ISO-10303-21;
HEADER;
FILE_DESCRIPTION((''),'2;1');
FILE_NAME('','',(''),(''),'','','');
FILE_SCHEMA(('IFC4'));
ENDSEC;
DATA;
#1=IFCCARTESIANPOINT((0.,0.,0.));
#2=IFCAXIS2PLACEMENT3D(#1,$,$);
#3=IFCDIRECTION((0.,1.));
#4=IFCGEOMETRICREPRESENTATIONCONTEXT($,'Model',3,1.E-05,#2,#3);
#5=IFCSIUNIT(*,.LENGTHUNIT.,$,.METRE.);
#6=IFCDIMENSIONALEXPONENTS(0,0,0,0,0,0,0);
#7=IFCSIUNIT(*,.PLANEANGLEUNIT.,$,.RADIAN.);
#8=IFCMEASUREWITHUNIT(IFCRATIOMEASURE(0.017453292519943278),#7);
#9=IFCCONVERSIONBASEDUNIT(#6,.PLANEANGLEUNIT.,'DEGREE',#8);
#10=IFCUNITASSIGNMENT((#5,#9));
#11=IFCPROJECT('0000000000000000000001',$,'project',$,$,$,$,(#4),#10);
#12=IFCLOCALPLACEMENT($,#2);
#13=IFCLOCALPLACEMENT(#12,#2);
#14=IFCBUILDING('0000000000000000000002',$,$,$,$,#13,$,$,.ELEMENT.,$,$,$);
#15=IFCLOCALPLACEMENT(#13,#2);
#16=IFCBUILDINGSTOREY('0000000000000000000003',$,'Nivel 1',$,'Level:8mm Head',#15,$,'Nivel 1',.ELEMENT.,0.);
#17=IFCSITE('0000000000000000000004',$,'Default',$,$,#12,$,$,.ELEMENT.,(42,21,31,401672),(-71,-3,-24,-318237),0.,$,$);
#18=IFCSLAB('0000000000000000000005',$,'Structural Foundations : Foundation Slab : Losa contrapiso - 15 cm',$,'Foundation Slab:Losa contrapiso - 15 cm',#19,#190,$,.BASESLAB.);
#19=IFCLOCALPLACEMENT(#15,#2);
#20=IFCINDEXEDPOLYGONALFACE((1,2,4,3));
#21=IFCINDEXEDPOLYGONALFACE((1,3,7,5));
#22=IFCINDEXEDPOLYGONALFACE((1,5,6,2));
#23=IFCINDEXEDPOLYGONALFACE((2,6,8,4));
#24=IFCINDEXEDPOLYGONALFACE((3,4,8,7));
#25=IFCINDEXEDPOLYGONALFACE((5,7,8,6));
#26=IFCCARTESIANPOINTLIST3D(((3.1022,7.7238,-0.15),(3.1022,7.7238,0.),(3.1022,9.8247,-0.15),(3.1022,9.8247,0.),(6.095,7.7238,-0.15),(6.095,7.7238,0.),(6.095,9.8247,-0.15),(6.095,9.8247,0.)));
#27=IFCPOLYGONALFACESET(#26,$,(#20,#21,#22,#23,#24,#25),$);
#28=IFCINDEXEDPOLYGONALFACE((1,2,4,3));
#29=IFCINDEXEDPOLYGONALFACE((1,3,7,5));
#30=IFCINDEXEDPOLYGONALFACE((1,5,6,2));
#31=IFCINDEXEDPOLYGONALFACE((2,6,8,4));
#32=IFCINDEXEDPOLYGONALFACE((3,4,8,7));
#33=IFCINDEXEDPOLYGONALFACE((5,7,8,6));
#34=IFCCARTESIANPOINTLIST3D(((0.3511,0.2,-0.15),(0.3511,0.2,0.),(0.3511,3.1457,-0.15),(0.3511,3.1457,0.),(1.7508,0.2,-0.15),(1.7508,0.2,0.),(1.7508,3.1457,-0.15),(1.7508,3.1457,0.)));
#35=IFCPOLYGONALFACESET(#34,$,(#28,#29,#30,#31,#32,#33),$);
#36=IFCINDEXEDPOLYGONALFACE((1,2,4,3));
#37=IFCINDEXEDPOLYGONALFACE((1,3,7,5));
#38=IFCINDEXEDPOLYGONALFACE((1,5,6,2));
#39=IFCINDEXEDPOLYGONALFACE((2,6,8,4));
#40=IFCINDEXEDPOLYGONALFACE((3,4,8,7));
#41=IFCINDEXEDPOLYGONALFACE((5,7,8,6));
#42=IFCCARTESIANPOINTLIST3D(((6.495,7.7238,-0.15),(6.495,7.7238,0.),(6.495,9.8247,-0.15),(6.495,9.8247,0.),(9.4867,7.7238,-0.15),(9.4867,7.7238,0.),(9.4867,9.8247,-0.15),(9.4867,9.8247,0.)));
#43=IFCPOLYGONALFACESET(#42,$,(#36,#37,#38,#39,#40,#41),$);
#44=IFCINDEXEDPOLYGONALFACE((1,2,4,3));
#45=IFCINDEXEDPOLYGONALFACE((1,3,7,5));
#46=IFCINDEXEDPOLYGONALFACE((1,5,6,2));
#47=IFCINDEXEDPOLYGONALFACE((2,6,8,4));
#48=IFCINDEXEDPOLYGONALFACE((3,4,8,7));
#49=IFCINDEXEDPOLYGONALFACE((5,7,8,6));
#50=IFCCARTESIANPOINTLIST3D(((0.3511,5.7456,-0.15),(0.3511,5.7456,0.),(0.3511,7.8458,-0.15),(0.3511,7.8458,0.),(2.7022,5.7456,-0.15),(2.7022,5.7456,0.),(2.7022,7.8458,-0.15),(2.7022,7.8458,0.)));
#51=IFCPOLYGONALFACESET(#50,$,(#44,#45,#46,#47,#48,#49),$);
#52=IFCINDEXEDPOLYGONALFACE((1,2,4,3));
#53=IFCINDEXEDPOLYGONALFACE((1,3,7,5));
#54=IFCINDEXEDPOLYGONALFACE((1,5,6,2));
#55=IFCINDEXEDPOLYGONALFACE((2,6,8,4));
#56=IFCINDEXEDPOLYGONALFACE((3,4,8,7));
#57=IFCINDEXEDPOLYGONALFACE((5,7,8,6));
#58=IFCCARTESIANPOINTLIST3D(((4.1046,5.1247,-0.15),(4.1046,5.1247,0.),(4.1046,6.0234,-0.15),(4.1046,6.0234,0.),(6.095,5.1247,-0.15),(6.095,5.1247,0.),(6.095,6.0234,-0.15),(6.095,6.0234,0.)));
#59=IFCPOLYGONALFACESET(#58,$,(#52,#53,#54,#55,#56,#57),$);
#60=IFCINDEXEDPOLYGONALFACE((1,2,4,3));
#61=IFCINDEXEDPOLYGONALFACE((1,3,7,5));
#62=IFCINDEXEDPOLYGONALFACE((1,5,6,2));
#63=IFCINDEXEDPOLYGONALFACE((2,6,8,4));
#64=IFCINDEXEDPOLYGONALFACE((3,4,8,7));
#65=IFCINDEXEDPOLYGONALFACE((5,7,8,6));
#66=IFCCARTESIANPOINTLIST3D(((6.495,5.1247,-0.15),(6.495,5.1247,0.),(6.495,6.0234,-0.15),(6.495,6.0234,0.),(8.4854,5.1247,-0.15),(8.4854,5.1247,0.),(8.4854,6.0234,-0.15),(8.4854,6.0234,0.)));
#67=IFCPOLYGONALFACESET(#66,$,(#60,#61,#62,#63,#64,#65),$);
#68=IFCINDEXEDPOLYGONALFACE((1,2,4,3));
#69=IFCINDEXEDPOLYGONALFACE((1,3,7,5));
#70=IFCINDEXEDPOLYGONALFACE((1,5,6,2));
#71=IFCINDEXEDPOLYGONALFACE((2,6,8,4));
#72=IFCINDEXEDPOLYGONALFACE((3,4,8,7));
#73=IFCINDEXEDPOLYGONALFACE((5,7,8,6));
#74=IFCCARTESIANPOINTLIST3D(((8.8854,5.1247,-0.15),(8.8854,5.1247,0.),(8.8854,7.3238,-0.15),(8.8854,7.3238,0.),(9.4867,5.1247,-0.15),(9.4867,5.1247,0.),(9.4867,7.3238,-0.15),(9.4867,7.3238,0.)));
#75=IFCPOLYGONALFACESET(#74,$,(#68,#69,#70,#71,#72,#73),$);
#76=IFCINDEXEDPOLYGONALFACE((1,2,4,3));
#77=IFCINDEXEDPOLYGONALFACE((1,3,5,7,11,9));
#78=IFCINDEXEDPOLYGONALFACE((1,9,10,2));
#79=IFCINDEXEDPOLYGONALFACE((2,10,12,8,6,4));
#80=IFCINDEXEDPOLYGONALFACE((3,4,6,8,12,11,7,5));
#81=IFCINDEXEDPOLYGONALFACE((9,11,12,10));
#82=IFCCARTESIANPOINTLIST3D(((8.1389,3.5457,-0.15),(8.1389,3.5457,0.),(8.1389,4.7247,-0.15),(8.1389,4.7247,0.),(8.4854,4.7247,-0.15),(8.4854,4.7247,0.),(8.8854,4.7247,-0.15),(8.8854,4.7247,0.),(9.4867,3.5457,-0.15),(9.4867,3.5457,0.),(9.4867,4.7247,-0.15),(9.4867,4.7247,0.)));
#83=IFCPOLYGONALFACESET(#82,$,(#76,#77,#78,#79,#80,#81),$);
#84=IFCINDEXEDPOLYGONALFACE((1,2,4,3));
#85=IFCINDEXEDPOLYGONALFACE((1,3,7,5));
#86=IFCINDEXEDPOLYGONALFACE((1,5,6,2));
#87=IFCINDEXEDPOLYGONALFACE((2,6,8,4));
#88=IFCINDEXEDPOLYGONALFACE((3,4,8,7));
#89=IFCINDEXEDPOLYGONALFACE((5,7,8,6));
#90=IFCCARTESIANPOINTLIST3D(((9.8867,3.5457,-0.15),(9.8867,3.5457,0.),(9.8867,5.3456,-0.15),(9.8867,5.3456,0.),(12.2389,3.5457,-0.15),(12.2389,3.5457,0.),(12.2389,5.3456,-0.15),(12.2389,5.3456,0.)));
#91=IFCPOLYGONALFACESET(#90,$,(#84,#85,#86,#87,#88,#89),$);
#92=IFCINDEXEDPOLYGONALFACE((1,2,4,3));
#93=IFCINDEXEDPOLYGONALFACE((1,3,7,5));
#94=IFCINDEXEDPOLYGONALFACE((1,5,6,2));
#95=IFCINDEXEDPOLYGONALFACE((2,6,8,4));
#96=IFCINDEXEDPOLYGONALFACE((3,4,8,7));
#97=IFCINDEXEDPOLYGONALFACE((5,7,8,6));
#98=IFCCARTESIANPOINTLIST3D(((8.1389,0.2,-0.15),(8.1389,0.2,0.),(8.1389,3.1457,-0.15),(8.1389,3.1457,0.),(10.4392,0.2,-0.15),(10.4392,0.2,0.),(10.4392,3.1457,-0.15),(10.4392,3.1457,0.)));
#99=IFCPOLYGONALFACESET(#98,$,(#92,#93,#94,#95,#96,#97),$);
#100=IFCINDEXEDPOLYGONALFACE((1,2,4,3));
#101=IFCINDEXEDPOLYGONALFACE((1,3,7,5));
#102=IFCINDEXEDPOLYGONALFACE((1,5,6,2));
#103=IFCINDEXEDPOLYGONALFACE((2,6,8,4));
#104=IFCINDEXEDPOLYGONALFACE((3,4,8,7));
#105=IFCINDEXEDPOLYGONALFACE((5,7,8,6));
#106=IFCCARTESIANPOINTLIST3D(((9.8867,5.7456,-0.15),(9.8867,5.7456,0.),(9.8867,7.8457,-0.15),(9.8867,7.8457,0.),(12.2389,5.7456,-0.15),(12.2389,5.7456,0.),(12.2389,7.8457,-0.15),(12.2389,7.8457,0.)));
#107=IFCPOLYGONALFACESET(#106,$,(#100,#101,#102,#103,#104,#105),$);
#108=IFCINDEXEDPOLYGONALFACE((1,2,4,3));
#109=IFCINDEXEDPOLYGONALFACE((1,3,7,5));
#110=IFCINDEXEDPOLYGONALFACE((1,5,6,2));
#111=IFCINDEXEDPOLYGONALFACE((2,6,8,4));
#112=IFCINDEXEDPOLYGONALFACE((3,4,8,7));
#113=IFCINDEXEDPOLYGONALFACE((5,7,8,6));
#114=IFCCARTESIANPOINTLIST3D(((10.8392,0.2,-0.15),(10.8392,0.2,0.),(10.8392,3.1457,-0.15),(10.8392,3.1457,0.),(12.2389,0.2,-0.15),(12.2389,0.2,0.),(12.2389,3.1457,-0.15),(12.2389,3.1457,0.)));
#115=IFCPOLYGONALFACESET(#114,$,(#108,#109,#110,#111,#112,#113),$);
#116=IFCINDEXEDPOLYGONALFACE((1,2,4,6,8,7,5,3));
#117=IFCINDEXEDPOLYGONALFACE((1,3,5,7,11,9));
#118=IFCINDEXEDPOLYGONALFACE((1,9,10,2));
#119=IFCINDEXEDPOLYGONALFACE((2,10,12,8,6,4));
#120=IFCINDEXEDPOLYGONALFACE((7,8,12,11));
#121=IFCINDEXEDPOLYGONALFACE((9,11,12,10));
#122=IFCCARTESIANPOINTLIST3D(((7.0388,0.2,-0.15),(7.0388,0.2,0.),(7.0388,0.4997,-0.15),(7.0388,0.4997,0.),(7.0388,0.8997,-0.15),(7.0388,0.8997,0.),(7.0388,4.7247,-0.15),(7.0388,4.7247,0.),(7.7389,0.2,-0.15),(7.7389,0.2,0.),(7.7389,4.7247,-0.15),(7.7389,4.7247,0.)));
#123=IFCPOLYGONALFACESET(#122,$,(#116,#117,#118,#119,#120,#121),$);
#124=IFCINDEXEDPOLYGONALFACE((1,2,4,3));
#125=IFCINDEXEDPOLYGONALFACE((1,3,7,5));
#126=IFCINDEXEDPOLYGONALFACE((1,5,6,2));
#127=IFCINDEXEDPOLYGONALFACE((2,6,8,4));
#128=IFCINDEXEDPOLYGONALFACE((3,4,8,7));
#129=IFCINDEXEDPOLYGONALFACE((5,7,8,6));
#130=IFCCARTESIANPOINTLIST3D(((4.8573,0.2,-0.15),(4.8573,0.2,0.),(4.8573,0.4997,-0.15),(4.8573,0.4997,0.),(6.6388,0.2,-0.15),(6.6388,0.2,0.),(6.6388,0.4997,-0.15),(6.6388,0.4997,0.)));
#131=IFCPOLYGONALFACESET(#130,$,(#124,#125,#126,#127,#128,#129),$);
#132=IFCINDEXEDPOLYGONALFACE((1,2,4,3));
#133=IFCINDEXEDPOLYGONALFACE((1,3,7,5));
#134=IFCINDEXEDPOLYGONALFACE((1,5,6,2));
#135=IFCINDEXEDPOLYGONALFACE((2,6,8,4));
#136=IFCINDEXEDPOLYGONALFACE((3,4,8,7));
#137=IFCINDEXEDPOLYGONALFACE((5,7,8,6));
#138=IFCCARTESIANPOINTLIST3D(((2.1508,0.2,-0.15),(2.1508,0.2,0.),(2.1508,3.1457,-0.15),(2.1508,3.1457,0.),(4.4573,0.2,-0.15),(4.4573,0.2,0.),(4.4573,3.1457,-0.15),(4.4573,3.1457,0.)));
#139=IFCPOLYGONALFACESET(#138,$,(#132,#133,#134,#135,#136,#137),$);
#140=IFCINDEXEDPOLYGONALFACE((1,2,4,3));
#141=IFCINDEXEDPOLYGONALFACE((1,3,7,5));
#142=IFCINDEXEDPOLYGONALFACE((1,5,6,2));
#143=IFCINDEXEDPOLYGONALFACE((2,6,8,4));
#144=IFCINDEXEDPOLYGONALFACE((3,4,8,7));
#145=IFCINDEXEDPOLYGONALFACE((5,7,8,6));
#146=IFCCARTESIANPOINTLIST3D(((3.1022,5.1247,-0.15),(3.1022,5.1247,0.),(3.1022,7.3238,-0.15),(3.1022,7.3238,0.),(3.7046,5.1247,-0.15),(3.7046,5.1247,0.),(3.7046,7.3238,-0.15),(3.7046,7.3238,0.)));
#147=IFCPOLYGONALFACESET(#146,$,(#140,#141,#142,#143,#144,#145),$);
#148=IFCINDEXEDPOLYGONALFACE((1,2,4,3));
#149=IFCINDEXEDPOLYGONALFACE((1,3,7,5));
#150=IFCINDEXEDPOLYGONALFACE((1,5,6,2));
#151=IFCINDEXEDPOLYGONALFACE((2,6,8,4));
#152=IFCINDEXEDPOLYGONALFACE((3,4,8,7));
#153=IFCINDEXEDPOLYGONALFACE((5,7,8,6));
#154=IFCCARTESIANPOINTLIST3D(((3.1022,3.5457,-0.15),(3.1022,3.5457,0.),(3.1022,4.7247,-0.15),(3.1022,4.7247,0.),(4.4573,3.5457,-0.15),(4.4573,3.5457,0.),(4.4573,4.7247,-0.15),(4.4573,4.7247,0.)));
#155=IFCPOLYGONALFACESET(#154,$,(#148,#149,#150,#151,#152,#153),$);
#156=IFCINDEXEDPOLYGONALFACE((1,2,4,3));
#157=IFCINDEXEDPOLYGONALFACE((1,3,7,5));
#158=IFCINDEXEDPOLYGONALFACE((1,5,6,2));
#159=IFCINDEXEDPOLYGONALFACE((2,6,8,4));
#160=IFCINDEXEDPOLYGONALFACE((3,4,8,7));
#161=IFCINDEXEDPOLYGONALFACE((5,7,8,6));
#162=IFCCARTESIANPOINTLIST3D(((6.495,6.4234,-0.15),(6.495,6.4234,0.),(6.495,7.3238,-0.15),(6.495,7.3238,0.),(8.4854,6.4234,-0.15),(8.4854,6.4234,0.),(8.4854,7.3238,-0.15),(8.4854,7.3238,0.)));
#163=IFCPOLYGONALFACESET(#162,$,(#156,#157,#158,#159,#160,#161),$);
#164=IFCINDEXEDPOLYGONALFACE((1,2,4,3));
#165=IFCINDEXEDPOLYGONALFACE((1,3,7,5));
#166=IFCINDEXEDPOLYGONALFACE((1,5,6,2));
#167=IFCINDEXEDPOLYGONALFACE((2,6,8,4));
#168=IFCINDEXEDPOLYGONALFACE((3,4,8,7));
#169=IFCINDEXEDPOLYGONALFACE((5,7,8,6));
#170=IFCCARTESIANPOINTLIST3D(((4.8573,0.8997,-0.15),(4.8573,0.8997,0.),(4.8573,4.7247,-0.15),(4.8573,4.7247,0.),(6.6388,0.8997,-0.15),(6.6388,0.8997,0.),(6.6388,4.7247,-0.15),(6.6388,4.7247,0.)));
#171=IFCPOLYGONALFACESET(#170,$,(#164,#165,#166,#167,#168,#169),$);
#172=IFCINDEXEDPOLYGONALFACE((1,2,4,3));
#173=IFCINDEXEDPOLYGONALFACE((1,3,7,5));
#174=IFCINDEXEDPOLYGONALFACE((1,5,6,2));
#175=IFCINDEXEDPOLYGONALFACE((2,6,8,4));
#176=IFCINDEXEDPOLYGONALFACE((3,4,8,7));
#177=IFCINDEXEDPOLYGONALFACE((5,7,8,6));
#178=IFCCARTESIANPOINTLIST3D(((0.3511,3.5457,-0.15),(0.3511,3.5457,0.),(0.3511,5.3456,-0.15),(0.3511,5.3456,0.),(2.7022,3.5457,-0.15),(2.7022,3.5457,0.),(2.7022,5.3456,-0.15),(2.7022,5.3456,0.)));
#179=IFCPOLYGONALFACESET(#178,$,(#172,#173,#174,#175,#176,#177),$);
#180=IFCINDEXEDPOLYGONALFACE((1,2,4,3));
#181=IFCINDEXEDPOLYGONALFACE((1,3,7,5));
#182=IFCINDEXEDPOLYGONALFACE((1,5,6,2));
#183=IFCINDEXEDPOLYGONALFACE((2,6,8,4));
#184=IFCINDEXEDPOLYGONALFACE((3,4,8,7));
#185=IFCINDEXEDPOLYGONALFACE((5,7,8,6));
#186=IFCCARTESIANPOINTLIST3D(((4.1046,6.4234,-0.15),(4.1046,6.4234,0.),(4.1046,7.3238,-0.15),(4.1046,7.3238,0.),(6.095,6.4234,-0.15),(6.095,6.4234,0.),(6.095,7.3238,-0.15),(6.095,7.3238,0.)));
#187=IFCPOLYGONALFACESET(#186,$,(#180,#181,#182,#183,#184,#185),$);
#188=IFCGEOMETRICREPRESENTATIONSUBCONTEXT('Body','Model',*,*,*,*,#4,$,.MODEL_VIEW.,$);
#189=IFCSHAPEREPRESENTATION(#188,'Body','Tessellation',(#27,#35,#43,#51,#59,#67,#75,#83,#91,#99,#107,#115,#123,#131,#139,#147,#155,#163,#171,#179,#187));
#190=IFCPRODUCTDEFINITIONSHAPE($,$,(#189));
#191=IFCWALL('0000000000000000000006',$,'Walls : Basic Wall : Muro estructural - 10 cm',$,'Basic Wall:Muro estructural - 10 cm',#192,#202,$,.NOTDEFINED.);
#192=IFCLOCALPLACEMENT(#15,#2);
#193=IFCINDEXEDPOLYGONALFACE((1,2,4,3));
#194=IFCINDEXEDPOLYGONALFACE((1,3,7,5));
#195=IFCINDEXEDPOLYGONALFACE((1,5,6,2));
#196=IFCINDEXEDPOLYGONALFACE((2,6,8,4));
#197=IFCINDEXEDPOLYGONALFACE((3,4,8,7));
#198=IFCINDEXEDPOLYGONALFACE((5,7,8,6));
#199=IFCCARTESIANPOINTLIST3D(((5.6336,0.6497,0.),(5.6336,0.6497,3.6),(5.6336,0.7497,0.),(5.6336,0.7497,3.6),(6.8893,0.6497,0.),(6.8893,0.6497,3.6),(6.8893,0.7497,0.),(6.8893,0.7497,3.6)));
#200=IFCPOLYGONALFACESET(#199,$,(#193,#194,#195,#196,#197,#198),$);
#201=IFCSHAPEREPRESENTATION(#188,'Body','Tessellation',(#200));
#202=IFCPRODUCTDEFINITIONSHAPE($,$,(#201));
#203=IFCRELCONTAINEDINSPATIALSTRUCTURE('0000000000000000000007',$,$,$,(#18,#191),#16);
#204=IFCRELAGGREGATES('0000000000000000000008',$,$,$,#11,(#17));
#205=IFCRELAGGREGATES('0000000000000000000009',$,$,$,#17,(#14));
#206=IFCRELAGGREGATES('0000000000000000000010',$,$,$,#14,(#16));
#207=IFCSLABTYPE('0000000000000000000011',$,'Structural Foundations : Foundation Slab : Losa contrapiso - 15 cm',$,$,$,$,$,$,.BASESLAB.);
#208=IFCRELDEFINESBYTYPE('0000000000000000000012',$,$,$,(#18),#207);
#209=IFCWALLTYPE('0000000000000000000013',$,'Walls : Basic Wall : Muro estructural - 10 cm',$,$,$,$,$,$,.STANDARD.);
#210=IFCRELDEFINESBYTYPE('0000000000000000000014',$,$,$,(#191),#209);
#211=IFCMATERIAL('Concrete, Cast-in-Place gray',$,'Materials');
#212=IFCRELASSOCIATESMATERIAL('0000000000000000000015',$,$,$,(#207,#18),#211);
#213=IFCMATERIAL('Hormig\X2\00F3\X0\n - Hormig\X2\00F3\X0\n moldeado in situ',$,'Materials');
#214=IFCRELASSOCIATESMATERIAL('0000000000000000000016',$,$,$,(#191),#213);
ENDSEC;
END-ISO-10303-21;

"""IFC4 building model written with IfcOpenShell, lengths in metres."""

from ifc_helpers import new_model, entity, si_unit, converted_unit, direction, frame, origin, place, context, subcontext, project, spatial, indexed_curve, outline, extrude, material, type_object, element, save


model = new_model("IFC4")

# Units and contexts
model_context = context("Model", 3, precision=1e-05, world=origin(), true_north=direction((0.0, 1.0)))
body_context = subcontext(model_context, "Body", "Model", "MODEL_VIEW")
ifc_project = project(units=[si_unit("LENGTHUNIT", "METRE"), converted_unit("PLANEANGLEUNIT", "DEGREE", entity("IfcRatioMeasure", 0.017453292519943278), si_unit("PLANEANGLEUNIT", "RADIAN"), dimensions=[0, 0, 0, 0, 0, 0, 0])], contexts=[model_context])

# Site, building, storey
site_placement = place(None, origin())
site = spatial("IfcSite", under=ifc_project, at=site_placement, Name="Default", CompositionType="ELEMENT", RefLatitude=(42, 21, 31, 401672), RefLongitude=(-71, -3, -24, -318237), RefElevation=0.0)
building_placement = place(site_placement, origin())
building = spatial("IfcBuilding", under=site, at=building_placement, CompositionType="ELEMENT")
storey_placement = place(building_placement, origin())
storey = spatial("IfcBuildingStorey", under=building, at=storey_placement, Name="Nivel 1", ObjectType="Level:8mm Head", LongName="Nivel 1", CompositionType="ELEMENT", Elevation=0.0)

# Slab
ifc_material_1 = material(Name="Concrete, Cast-in-Place gray", Category="Materials")
slab_type = type_object("IfcSlabType", Name="Structural Foundations : Foundation Slab : Losa contrapiso - 15 cm", PredefinedType="BASESLAB", material=ifc_material_1)
slab_placement = place(storey_placement, origin())
element("IfcSlab", 1, at=slab_placement, inside=storey, type_object=slab_type, material=ifc_material_1, Name="Structural Foundations : Foundation Slab : Losa contrapiso - 15 cm", ObjectType="Foundation Slab:Losa contrapiso - 15 cm", PredefinedType="BASESLAB", context=body_context, shape_type="SweptSolid", body=[
    extrude(outline(indexed_curve([(-1.0505, -1.4964), (1.0505, -1.4964), (1.0505, 1.4964), (-1.0505, 1.4964), (-1.0505, -1.4964)], self_intersect=False)), frame((4.5986, 8.7743, -0.15), z_axis=(0.0, 0.0, 1.0), x_axis=(0.0, -1.0, 0.0)), (0.0, 0.0, 1.0), 0.15),
    extrude(outline(indexed_curve([(-0.6998, -1.4729), (0.6998, -1.4729), (0.6998, 1.4729), (-0.6998, 1.4729), (-0.6998, -1.4729)], self_intersect=False)), frame((1.051, 1.6729, -0.15), z_axis=(0.0, 0.0, 1.0), x_axis=(-1.0, 0.0, 0.0)), (0.0, 0.0, 1.0), 0.15),
    extrude(outline(indexed_curve([(-1.4958, -1.0505), (1.4958, -1.0505), (1.4958, 1.0505), (-1.4958, 1.0505), (-1.4958, -1.0505)], self_intersect=False)), frame((7.9908, 8.7743, -0.15)), (0.0, 0.0, 1.0), 0.15),
    extrude(outline(indexed_curve([(-1.1755, -1.0501), (1.1755, -1.0501), (1.1755, 1.0501), (-1.1755, 1.0501), (-1.1755, -1.0501)], self_intersect=False)), frame((1.5266, 6.7957, -0.15), z_axis=(0.0, 0.0, 1.0), x_axis=(-1.0, 0.0, 0.0)), (0.0, 0.0, 1.0), 0.15),
    extrude(outline(indexed_curve([(-0.4493, -0.9952), (0.4493, -0.9952), (0.4493, 0.9952), (-0.4493, 0.9952), (-0.4493, -0.9952)], self_intersect=False)), frame((5.0998, 5.574, -0.15), z_axis=(0.0, 0.0, 1.0), x_axis=(0.0, 1.0, 0.0)), (0.0, 0.0, 1.0), 0.15),
    extrude(outline(indexed_curve([(-0.9952, -0.4493), (0.9952, -0.4493), (0.9952, 0.4493), (-0.9952, 0.4493), (-0.9952, -0.4493)], self_intersect=False)), frame((7.4902, 5.574, -0.15)), (0.0, 0.0, 1.0), 0.15),
    extrude(outline(indexed_curve([(-0.3007, -1.0996), (0.3007, -1.0996), (0.3007, 1.0996), (-0.3007, 1.0996), (-0.3007, -1.0996)], self_intersect=False)), frame((9.186, 6.2242, -0.15), z_axis=(0.0, 0.0, 1.0), x_axis=(-1.0, 0.0, 0.0)), (0.0, 0.0, 1.0), 0.15),
    extrude(outline(indexed_curve([(-0.786, -0.7164), (0.393, -0.7164), (0.393, -0.1151), (0.393, 0.2849), (0.393, 0.6314), (-0.786, 0.6314), (-0.786, -0.7164)], self_intersect=False)), frame((8.7703, 4.3317, -0.15), z_axis=(0.0, 0.0, 1.0), x_axis=(0.0, 1.0, 0.0)), (0.0, 0.0, 1.0), 0.15),
    extrude(outline(indexed_curve([(-0.8999, -1.1761), (0.8999, -1.1761), (0.8999, 1.1761), (-0.8999, 1.1761), (-0.8999, -1.1761)], self_intersect=False)), frame((11.0628, 4.4456, -0.15), z_axis=(0.0, 0.0, 1.0), x_axis=(0.0, -1.0, 0.0)), (0.0, 0.0, 1.0), 0.15),
    extrude(outline(indexed_curve([(-1.4729, -1.1502), (1.4729, -1.1502), (1.4729, 1.1502), (-1.4729, 1.1502), (-1.4729, -1.1502)], self_intersect=False)), frame((9.289, 1.6729, -0.15), z_axis=(0.0, 0.0, 1.0), x_axis=(0.0, -1.0, 0.0)), (0.0, 0.0, 1.0), 0.15),
    extrude(outline(indexed_curve([(-1.05, -1.1761), (1.05, -1.1761), (1.05, 1.1761), (-1.05, 1.1761), (-1.05, -1.1761)], self_intersect=False)), frame((11.0628, 6.7956, -0.15), z_axis=(0.0, 0.0, 1.0), x_axis=(0.0, -1.0, 0.0)), (0.0, 0.0, 1.0), 0.15),
    extrude(outline(indexed_curve([(-1.4729, -0.6998), (1.4729, -0.6998), (1.4729, 0.6998), (-1.4729, 0.6998), (-1.4729, -0.6998)], self_intersect=False)), frame((11.539, 1.6729, -0.15), z_axis=(0.0, 0.0, 1.0), x_axis=(0.0, -1.0, 0.0)), (0.0, 0.0, 1.0), 0.15),
    extrude(outline(indexed_curve([(-2.8499, -0.2334), (0.9751, -0.2334), (1.3751, -0.2334), (1.6748, -0.2334), (1.6748, 0.4667), (-2.8499, 0.4667), (-2.8499, -0.2334)], self_intersect=False)), frame((7.2722, 1.8748, -0.15), z_axis=(0.0, 0.0, 1.0), x_axis=(0.0, -1.0, 0.0)), (0.0, 0.0, 1.0), 0.15),
    extrude(outline(indexed_curve([(-0.1498, -0.8908), (0.1498, -0.8908), (0.1498, 0.8908), (-0.1498, 0.8908), (-0.1498, -0.8908)], self_intersect=False)), frame((5.748, 0.3498, -0.15), z_axis=(0.0, 0.0, 1.0), x_axis=(0.0, -1.0, 0.0)), (0.0, 0.0, 1.0), 0.15),
    extrude(outline(indexed_curve([(-1.4729, -1.1532), (1.4729, -1.1532), (1.4729, 1.1532), (-1.4729, 1.1532), (-1.4729, -1.1532)], self_intersect=False)), frame((3.304, 1.6729, -0.15), z_axis=(0.0, 0.0, 1.0), x_axis=(0.0, -1.0, 0.0)), (0.0, 0.0, 1.0), 0.15),
    extrude(outline(indexed_curve([(-1.0996, -0.3012), (1.0996, -0.3012), (1.0996, 0.3012), (-1.0996, 0.3012), (-1.0996, -0.3012)], self_intersect=False)), frame((3.4034, 6.2242, -0.15), z_axis=(0.0, 0.0, 1.0), x_axis=(0.0, -1.0, 0.0)), (0.0, 0.0, 1.0), 0.15),
    extrude(outline(indexed_curve([(-0.5895, -0.6776), (0.5895, -0.6776), (0.5895, 0.6776), (-0.5895, 0.6776), (-0.5895, -0.6776)], self_intersect=False)), frame((3.7797, 4.1352, -0.15), z_axis=(0.0, 0.0, 1.0), x_axis=(0.0, 1.0, 0.0)), (0.0, 0.0, 1.0), 0.15),
    extrude(outline(indexed_curve([(-0.9952, -0.4502), (0.9952, -0.4502), (0.9952, 0.4502), (-0.9952, 0.4502), (-0.9952, -0.4502)], self_intersect=False)), frame((7.4902, 6.8736, -0.15)), (0.0, 0.0, 1.0), 0.15),
    extrude(outline(indexed_curve([(-1.9125, -0.8908), (1.9125, -0.8908), (1.9125, 0.8908), (-1.9125, 0.8908), (-1.9125, -0.8908)], self_intersect=False)), frame((5.748, 2.8122, -0.15), z_axis=(0.0, 0.0, 1.0), x_axis=(0.0, -1.0, 0.0)), (0.0, 0.0, 1.0), 0.15),
    extrude(outline(indexed_curve([(-1.1755, -0.8999), (1.1755, -0.8999), (1.1755, 0.8999), (-1.1755, 0.8999), (-1.1755, -0.8999)], self_intersect=False)), frame((1.5266, 4.4456, -0.15), z_axis=(0.0, 0.0, 1.0), x_axis=(-1.0, 0.0, 0.0)), (0.0, 0.0, 1.0), 0.15),
    extrude(outline(indexed_curve([(-0.4502, -0.9952), (0.4502, -0.9952), (0.4502, 0.9952), (-0.4502, 0.9952), (-0.4502, -0.9952)], self_intersect=False)), frame((5.0998, 6.8736, -0.15), z_axis=(0.0, 0.0, 1.0), x_axis=(0.0, -1.0, 0.0)), (0.0, 0.0, 1.0), 0.15),
])

# Wall
ifc_material_2 = material(Name="Hormigón - Hormigón moldeado in situ", Category="Materials")
wall_type_1 = type_object("IfcWallType", Name="Walls : Basic Wall : Muro estructural - 10 cm", PredefinedType="STANDARD")
wall_1_placement = place(storey_placement, frame((5.6336, 0.6997, 0.0)))
element("IfcWall", 2, at=wall_1_placement, inside=storey, type_object=wall_type_1, material=ifc_material_2, Name="Walls : Basic Wall : Muro estructural - 10 cm", ObjectType="Basic Wall:Muro estructural - 10 cm", PredefinedType="NOTDEFINED", context=body_context, shape_type="SweptSolid", body=[
    extrude(outline(indexed_curve([(1.2557, 0.05), (0.0, 0.05), (0.0, -0.05), (1.2557, -0.05), (1.2557, 0.05)], self_intersect=False)), origin(), (0.0, 0.0, 1.0), 3.6),
])

save(model, "model.ifc")
